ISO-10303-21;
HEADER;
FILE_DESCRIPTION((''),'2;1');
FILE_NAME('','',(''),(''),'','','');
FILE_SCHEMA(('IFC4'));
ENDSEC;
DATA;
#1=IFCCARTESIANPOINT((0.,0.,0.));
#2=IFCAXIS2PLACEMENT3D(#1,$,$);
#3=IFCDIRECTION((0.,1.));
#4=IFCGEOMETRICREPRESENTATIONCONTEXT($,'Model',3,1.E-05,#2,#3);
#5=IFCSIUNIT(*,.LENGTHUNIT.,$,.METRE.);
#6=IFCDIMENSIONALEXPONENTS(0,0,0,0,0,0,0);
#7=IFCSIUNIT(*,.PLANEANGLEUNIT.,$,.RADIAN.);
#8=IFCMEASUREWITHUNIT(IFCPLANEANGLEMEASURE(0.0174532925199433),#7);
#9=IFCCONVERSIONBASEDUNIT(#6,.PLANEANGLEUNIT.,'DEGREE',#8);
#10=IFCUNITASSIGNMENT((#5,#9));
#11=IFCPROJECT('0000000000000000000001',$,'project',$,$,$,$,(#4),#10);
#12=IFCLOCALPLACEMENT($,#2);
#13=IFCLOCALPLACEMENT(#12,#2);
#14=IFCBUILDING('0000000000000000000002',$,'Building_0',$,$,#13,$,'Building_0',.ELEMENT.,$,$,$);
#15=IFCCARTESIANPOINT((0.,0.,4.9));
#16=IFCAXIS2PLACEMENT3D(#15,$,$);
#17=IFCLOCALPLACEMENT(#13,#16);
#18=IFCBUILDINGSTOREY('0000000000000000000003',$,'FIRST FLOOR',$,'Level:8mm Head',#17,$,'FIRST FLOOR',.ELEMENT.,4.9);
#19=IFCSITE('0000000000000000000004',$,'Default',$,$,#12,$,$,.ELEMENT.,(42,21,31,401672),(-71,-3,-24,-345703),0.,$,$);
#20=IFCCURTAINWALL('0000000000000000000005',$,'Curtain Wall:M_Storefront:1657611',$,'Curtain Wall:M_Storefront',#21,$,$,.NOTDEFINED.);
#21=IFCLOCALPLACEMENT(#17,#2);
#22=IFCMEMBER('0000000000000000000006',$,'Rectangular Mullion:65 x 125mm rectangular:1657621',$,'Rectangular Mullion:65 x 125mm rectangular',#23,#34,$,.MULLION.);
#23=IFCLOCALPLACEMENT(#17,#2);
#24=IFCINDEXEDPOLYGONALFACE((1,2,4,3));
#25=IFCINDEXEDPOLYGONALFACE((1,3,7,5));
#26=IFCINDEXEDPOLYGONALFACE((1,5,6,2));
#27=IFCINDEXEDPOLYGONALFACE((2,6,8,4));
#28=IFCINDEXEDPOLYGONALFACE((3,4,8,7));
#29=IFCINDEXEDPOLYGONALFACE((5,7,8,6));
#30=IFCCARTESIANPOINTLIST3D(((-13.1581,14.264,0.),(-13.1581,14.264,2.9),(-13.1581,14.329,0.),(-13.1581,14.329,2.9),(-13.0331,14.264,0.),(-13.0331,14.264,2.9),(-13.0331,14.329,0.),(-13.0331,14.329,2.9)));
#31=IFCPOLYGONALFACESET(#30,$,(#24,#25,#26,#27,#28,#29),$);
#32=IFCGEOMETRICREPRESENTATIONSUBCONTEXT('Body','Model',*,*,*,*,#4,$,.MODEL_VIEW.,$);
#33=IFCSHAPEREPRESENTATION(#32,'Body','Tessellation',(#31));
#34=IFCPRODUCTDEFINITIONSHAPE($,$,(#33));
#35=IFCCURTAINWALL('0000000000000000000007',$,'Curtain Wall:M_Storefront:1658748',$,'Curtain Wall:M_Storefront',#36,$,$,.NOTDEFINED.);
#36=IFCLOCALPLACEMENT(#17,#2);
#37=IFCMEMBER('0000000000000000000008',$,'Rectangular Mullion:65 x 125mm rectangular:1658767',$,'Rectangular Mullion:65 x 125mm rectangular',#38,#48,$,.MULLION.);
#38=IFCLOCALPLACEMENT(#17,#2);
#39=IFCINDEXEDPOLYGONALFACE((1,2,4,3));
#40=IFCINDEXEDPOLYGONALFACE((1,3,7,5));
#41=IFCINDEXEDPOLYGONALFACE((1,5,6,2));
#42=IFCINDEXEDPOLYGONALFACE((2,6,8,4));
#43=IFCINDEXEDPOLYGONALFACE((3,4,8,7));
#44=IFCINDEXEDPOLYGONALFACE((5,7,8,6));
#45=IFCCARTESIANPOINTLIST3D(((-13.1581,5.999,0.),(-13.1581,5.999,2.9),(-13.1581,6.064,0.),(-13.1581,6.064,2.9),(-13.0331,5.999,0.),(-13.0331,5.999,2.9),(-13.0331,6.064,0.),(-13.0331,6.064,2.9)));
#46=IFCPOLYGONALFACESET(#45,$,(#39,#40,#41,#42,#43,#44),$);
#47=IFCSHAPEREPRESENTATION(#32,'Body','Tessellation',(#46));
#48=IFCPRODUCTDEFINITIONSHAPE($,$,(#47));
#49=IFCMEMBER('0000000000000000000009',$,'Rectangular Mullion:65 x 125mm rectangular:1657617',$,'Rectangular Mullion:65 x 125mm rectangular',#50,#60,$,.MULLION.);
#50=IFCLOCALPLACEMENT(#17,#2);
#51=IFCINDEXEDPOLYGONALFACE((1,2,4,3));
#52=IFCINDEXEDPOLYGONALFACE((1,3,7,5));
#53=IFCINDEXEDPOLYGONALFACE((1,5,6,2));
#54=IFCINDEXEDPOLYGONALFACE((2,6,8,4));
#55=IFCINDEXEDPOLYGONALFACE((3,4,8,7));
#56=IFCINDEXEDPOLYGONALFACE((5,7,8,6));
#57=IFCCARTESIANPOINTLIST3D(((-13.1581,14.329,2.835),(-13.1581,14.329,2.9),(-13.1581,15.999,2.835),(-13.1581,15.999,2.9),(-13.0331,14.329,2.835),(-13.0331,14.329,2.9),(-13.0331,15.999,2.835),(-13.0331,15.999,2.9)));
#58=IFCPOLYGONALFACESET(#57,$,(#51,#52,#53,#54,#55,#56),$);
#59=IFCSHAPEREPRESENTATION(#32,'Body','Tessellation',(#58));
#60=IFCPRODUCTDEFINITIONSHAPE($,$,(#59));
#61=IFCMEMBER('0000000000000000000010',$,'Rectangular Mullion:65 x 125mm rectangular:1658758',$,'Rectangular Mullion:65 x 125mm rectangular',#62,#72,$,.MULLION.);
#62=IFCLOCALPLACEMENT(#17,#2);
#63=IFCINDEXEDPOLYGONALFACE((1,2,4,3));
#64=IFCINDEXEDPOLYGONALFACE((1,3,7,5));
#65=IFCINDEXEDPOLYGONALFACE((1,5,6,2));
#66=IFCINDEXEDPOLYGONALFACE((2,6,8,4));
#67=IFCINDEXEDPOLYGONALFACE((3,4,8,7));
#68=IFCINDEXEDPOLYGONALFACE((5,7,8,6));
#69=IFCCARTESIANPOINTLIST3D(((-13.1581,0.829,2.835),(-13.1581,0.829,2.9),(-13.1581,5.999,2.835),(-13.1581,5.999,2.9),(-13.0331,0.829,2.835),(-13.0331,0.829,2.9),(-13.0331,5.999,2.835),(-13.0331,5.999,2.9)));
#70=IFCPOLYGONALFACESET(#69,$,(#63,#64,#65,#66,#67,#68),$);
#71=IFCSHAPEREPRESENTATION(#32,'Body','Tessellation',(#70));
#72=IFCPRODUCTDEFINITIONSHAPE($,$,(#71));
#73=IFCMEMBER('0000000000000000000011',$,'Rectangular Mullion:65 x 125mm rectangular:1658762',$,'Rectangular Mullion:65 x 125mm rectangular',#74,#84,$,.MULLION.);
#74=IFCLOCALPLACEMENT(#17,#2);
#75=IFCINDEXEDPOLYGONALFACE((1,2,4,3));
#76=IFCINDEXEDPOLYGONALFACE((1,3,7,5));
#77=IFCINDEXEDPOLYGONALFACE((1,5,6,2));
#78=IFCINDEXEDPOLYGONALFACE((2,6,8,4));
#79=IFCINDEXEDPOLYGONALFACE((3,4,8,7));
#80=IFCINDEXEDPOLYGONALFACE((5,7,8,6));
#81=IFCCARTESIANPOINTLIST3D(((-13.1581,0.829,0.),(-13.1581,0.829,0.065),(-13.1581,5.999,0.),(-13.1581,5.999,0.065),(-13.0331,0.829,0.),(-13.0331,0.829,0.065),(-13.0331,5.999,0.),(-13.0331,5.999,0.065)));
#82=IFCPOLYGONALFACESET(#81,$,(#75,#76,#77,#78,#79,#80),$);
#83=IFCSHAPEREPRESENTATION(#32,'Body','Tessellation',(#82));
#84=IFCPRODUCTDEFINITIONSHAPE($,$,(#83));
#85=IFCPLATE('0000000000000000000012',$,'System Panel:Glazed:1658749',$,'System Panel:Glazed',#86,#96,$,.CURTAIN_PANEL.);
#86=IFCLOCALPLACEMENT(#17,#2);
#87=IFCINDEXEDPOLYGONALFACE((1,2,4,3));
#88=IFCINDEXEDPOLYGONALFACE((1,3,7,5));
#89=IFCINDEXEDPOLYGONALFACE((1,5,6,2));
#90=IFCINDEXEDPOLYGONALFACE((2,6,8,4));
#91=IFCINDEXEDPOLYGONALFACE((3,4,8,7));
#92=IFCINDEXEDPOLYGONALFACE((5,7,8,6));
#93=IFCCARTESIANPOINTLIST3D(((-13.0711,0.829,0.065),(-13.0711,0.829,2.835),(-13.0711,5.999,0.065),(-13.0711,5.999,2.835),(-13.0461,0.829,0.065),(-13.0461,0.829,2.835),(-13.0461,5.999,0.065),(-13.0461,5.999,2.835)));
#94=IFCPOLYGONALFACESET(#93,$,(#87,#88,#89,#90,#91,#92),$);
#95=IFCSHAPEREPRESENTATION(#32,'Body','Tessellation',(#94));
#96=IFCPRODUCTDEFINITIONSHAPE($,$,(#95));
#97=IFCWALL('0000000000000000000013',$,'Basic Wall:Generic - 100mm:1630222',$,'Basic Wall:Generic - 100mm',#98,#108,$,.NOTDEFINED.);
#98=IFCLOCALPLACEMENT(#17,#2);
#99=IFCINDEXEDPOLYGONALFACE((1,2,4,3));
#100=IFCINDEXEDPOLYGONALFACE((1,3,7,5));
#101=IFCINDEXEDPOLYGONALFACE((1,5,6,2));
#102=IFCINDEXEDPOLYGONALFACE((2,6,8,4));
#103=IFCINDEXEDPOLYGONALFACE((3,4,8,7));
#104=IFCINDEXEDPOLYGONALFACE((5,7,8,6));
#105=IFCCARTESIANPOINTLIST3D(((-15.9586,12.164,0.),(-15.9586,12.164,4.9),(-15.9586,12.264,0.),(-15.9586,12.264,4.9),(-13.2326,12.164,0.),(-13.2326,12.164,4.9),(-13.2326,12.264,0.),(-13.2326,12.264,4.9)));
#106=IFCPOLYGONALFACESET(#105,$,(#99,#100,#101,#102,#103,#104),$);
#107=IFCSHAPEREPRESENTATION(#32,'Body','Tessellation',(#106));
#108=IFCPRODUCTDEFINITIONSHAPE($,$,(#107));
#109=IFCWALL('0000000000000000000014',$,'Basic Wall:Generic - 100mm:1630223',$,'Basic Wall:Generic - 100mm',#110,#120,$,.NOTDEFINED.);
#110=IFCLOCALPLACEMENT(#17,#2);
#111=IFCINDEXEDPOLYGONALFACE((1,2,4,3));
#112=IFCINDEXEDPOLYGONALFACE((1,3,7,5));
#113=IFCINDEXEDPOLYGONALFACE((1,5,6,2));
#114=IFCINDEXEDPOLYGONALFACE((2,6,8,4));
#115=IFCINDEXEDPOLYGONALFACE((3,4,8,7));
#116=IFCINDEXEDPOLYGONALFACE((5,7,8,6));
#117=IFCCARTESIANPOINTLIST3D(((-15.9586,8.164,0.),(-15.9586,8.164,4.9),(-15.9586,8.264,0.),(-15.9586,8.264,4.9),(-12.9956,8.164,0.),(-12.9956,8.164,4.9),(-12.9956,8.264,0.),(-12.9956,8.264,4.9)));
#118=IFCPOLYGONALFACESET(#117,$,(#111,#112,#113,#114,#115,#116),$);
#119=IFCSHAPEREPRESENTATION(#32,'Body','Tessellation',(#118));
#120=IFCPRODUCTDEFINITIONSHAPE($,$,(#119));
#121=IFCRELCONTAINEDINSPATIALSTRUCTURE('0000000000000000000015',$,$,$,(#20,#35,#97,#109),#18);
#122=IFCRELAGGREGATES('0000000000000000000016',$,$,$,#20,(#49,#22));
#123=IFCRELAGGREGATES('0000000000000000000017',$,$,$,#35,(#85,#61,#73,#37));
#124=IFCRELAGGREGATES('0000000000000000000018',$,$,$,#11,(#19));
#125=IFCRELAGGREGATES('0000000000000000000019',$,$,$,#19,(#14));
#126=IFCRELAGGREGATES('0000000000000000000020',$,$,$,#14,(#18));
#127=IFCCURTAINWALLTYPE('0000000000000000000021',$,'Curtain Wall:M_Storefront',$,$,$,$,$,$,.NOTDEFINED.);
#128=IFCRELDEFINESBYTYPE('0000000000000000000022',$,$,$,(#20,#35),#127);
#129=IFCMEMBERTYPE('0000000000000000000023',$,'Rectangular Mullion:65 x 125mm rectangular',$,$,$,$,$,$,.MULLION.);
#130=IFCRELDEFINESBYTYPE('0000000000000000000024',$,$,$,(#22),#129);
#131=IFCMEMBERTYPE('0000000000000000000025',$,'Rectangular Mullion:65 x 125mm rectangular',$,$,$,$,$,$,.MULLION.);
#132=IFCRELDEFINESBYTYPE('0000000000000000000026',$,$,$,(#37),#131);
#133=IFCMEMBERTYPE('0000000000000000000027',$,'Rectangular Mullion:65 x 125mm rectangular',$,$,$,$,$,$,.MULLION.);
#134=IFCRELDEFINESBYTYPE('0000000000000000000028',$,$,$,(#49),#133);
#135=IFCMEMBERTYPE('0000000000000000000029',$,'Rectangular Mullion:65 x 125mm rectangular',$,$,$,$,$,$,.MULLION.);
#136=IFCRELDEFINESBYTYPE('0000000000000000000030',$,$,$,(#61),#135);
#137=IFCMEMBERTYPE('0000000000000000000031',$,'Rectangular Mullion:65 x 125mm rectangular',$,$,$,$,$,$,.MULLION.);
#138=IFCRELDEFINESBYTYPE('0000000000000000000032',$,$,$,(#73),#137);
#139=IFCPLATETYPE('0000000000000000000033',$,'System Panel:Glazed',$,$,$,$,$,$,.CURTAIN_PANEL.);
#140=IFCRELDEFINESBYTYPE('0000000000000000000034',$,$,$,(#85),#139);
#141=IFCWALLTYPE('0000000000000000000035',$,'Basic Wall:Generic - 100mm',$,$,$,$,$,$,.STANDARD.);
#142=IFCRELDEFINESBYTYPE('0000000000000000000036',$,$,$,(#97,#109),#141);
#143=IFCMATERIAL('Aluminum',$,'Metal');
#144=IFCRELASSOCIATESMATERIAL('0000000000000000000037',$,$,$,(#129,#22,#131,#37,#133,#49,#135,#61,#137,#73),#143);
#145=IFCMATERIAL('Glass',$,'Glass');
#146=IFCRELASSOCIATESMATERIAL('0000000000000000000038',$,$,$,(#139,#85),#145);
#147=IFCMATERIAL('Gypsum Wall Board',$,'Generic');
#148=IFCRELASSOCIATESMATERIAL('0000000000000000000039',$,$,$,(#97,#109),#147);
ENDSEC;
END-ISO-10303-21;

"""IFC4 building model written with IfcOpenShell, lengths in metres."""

from ifc_helpers import new_model, entity, si_unit, converted_unit, direction, frame, origin, place, context, subcontext, project, spatial, indexed_curve, outline, extrude, source, transform, mapped, material, type_object, type_shapes, element, aggregate, save


model = new_model("IFC4")

# Units and contexts
model_context = context("Model", 3, precision=1e-05, world=origin(), true_north=direction((0.0, 1.0)))
body_context = subcontext(model_context, "Body", "Model", "MODEL_VIEW")
ifc_project = project(units=[si_unit("LENGTHUNIT", "METRE"), converted_unit("PLANEANGLEUNIT", "DEGREE", entity("IfcPlaneAngleMeasure", 0.0174532925199433), si_unit("PLANEANGLEUNIT", "RADIAN"), dimensions=[0, 0, 0, 0, 0, 0, 0])], contexts=[model_context])

# Site, building, storey
site_placement = place(None, origin())
site = spatial("IfcSite", under=ifc_project, at=site_placement, Name="Default", CompositionType="ELEMENT", RefLatitude=(42, 21, 31, 401672), RefLongitude=(-71, -3, -24, -345703), RefElevation=0.0)
building_placement = place(site_placement, origin())
building = spatial("IfcBuilding", under=site, at=building_placement, Name="Building_0", LongName="Building_0", CompositionType="ELEMENT")
storey_placement = place(building_placement, frame((0.0, 0.0, 4.9)))
storey = spatial("IfcBuildingStorey", under=building, at=storey_placement, Name="FIRST FLOOR", ObjectType="Level:8mm Head", LongName="FIRST FLOOR", CompositionType="ELEMENT", Elevation=4.9)

# Curtain walls, members
curtain_wall_type = type_object("IfcCurtainWallType", Name="Curtain Wall:M_Storefront", PredefinedType="NOTDEFINED")
curtain_wall_1_placement = place(storey_placement, frame((0.0, 0.0, -4.9)))
curtain_wall_1 = element("IfcCurtainWall", 1, at=curtain_wall_1_placement, inside=storey, type_object=curtain_wall_type, Name="Curtain Wall:M_Storefront:1657611", ObjectType="Curtain Wall:M_Storefront", PredefinedType="NOTDEFINED")
ifc_material_1 = material(Name="Aluminum", Category="Metal")
member_type_1 = type_object("IfcMemberType", Name="Rectangular Mullion:65 x 125mm rectangular", PredefinedType="MULLION", material=ifc_material_1)
shared_shape_1 = source(origin(), body_context, "Body", "SweptSolid", [
    extrude(outline(indexed_curve([(-0.0325, -0.0625), (0.0325, -0.0625), (0.0325, 0.0625), (-0.0325, 0.0625), (-0.0325, -0.0625)], self_intersect=False)), frame((-0.0325, 0.0, -2.9), z_axis=(0.0, 0.0, 1.0), x_axis=(-1.0, 0.0, 0.0)), (0.0, 0.0, 1.0), 2.9),
])
type_shapes(member_type_1, [shared_shape_1])
member_1_placement = place(curtain_wall_1_placement, frame((-13.0956, 14.264, 4.9), z_axis=(0.0, 0.0, -1.0), x_axis=(0.0, -1.0, 0.0)))
member_1 = element("IfcMember", 2, at=member_1_placement, type_object=member_type_1, material=ifc_material_1, Name="Rectangular Mullion:65 x 125mm rectangular:1657621", ObjectType="Rectangular Mullion:65 x 125mm rectangular", PredefinedType="MULLION", context=body_context, shape_type="MappedRepresentation", body=[
    mapped(shared_shape_1, transform((0.0, 0.0, 0.0), scale=1.0)),
])
curtain_wall_2_placement = place(storey_placement, frame((0.0, 0.0, -4.9)))
curtain_wall_2 = element("IfcCurtainWall", 3, at=curtain_wall_2_placement, inside=storey, type_object=curtain_wall_type, Name="Curtain Wall:M_Storefront:1658748", ObjectType="Curtain Wall:M_Storefront", PredefinedType="NOTDEFINED")
member_type_2 = type_object("IfcMemberType", Name="Rectangular Mullion:65 x 125mm rectangular", PredefinedType="MULLION", material=ifc_material_1)
shared_shape_2 = source(origin(), body_context, "Body", "SweptSolid", [
    extrude(outline(indexed_curve([(-0.0325, -0.0625), (0.0325, -0.0625), (0.0325, 0.0625), (-0.0325, 0.0625), (-0.0325, -0.0625)], self_intersect=False)), frame((-0.0325, 0.0, -2.9), z_axis=(0.0, 0.0, 1.0), x_axis=(-1.0, 0.0, 0.0)), (0.0, 0.0, 1.0), 2.9),
])
type_shapes(member_type_2, [shared_shape_2])
member_2_placement = place(curtain_wall_2_placement, frame((-13.0956, 6.064, 7.8), z_axis=(0.0, 0.0, 1.0), x_axis=(0.0, 1.0, 0.0)))
member_2 = element("IfcMember", 4, at=member_2_placement, type_object=member_type_2, material=ifc_material_1, Name="Rectangular Mullion:65 x 125mm rectangular:1658767", ObjectType="Rectangular Mullion:65 x 125mm rectangular", PredefinedType="MULLION", context=body_context, shape_type="MappedRepresentation", body=[
    mapped(shared_shape_2, transform((0.0, 0.0, 0.0), scale=1.0)),
])

# Members
member_type_3 = type_object("IfcMemberType", Name="Rectangular Mullion:65 x 125mm rectangular", PredefinedType="MULLION", material=ifc_material_1)
shared_shape_3 = source(origin(), body_context, "Body", "SweptSolid", [
    extrude(outline(indexed_curve([(-0.0325, -0.0625), (0.0325, -0.0625), (0.0325, 0.0625), (-0.0325, 0.0625), (-0.0325, -0.0625)], self_intersect=False)), frame((-0.0325, 0.0, -1.67), z_axis=(0.0, 0.0, 1.0), x_axis=(-1.0, 0.0, 0.0)), (0.0, 0.0, 1.0), 1.67),
])
type_shapes(member_type_3, [shared_shape_3])
member_3_placement = place(curtain_wall_1_placement, frame((-13.0956, 14.329, 7.8), z_axis=(0.0, -1.0, 0.0), x_axis=(0.0, 0.0, 1.0)))
member_3 = element("IfcMember", 5, at=member_3_placement, type_object=member_type_3, material=ifc_material_1, Name="Rectangular Mullion:65 x 125mm rectangular:1657617", ObjectType="Rectangular Mullion:65 x 125mm rectangular", PredefinedType="MULLION", context=body_context, shape_type="MappedRepresentation", body=[
    mapped(shared_shape_3, transform((0.0, 0.0, 0.0), scale=1.0)),
])
aggregate(curtain_wall_1, [member_3, member_1])
member_type_4 = type_object("IfcMemberType", Name="Rectangular Mullion:65 x 125mm rectangular", PredefinedType="MULLION", material=ifc_material_1)
shared_shape_4 = source(origin(), body_context, "Body", "SweptSolid", [
    extrude(outline(indexed_curve([(-0.0325, -0.0625), (0.0325, -0.0625), (0.0325, 0.0625), (-0.0325, 0.0625), (-0.0325, -0.0625)], self_intersect=False)), frame((-0.0325, 0.0, -5.17), z_axis=(0.0, 0.0, 1.0), x_axis=(-1.0, 0.0, 0.0)), (0.0, 0.0, 1.0), 5.17),
])
type_shapes(member_type_4, [shared_shape_4])
member_4_placement = place(curtain_wall_2_placement, frame((-13.0956, 0.829, 7.8), z_axis=(0.0, -1.0, 0.0), x_axis=(0.0, 0.0, 1.0)))
member_4 = element("IfcMember", 6, at=member_4_placement, type_object=member_type_4, material=ifc_material_1, Name="Rectangular Mullion:65 x 125mm rectangular:1658758", ObjectType="Rectangular Mullion:65 x 125mm rectangular", PredefinedType="MULLION", context=body_context, shape_type="MappedRepresentation", body=[
    mapped(shared_shape_4, transform((0.0, 0.0, 0.0), scale=1.0)),
])
member_type_5 = type_object("IfcMemberType", Name="Rectangular Mullion:65 x 125mm rectangular", PredefinedType="MULLION", material=ifc_material_1)
shared_shape_5 = source(origin(), body_context, "Body", "SweptSolid", [
    extrude(outline(indexed_curve([(-0.0325, -0.0625), (0.0325, -0.0625), (0.0325, 0.0625), (-0.0325, 0.0625), (-0.0325, -0.0625)], self_intersect=False)), frame((-0.0325, 0.0, -5.17), z_axis=(0.0, 0.0, 1.0), x_axis=(-1.0, 0.0, 0.0)), (0.0, 0.0, 1.0), 5.17),
])
type_shapes(member_type_5, [shared_shape_5])
member_5_placement = place(curtain_wall_2_placement, frame((-13.0956, 5.999, 4.9), z_axis=(0.0, 1.0, 0.0), x_axis=(0.0, 0.0, -1.0)))
member_5 = element("IfcMember", 7, at=member_5_placement, type_object=member_type_5, material=ifc_material_1, Name="Rectangular Mullion:65 x 125mm rectangular:1658762", ObjectType="Rectangular Mullion:65 x 125mm rectangular", PredefinedType="MULLION", context=body_context, shape_type="MappedRepresentation", body=[
    mapped(shared_shape_5, transform((0.0, 0.0, 0.0), scale=1.0)),
])

# Plate
ifc_material_2 = material(Name="Glass", Category="Glass")
plate_type = type_object("IfcPlateType", Name="System Panel:Glazed", PredefinedType="CURTAIN_PANEL", material=ifc_material_2)
shared_shape_6 = source(origin(), body_context, "Body", "SweptSolid", [
    extrude(outline(indexed_curve([(-0.0125, -2.585), (0.0125, -2.585), (0.0125, 2.585), (-0.0125, 2.585), (-0.0125, -2.585)], self_intersect=False)), frame((0.0, 0.037, 0.0), z_axis=(0.0, 0.0, 1.0), x_axis=(0.0, 1.0, 0.0)), (0.0, 0.0, 1.0), 2.77),
])
type_shapes(plate_type, [shared_shape_6])
plate_placement = place(curtain_wall_2_placement, frame((-13.0956, 3.414, 4.965), z_axis=(0.0, 0.0, 1.0), x_axis=(0.0, -1.0, 0.0)))
plate = element("IfcPlate", 8, at=plate_placement, type_object=plate_type, material=ifc_material_2, Name="System Panel:Glazed:1658749", ObjectType="System Panel:Glazed", PredefinedType="CURTAIN_PANEL", context=body_context, shape_type="MappedRepresentation", body=[
    mapped(shared_shape_6, transform((0.0, 0.0, 0.0), scale=1.0)),
])
aggregate(curtain_wall_2, [plate, member_4, member_5, member_2])

# Walls
ifc_material_3 = material(Name="Gypsum Wall Board", Category="Generic")
wall_type_1 = type_object("IfcWallType", Name="Basic Wall:Generic - 100mm", PredefinedType="STANDARD")
wall_1_placement = place(storey_placement, frame((-15.9586, 12.214, 0.0)))
element("IfcWall", 9, at=wall_1_placement, inside=storey, type_object=wall_type_1, material=ifc_material_3, Name="Basic Wall:Generic - 100mm:1630222", ObjectType="Basic Wall:Generic - 100mm", PredefinedType="NOTDEFINED", context=body_context, shape_type="SweptSolid", body=[
    extrude(outline(indexed_curve([(2.726, 0.05), (0.0, 0.05), (0.0, -0.05), (2.726, -0.05), (2.726, 0.05)], self_intersect=False)), origin(), (0.0, 0.0, 1.0), 4.9),
])
wall_2_placement = place(storey_placement, frame((-15.9586, 8.214, 0.0)))
element("IfcWall", 10, at=wall_2_placement, inside=storey, type_object=wall_type_1, material=ifc_material_3, Name="Basic Wall:Generic - 100mm:1630223", ObjectType="Basic Wall:Generic - 100mm", PredefinedType="NOTDEFINED", context=body_context, shape_type="SweptSolid", body=[
    extrude(outline(indexed_curve([(2.963, 0.05), (0.0, 0.05), (0.0, -0.05), (2.963, -0.05), (2.963, 0.05)], self_intersect=False)), origin(), (0.0, 0.0, 1.0), 4.9),
])

save(model, "model.ifc")
